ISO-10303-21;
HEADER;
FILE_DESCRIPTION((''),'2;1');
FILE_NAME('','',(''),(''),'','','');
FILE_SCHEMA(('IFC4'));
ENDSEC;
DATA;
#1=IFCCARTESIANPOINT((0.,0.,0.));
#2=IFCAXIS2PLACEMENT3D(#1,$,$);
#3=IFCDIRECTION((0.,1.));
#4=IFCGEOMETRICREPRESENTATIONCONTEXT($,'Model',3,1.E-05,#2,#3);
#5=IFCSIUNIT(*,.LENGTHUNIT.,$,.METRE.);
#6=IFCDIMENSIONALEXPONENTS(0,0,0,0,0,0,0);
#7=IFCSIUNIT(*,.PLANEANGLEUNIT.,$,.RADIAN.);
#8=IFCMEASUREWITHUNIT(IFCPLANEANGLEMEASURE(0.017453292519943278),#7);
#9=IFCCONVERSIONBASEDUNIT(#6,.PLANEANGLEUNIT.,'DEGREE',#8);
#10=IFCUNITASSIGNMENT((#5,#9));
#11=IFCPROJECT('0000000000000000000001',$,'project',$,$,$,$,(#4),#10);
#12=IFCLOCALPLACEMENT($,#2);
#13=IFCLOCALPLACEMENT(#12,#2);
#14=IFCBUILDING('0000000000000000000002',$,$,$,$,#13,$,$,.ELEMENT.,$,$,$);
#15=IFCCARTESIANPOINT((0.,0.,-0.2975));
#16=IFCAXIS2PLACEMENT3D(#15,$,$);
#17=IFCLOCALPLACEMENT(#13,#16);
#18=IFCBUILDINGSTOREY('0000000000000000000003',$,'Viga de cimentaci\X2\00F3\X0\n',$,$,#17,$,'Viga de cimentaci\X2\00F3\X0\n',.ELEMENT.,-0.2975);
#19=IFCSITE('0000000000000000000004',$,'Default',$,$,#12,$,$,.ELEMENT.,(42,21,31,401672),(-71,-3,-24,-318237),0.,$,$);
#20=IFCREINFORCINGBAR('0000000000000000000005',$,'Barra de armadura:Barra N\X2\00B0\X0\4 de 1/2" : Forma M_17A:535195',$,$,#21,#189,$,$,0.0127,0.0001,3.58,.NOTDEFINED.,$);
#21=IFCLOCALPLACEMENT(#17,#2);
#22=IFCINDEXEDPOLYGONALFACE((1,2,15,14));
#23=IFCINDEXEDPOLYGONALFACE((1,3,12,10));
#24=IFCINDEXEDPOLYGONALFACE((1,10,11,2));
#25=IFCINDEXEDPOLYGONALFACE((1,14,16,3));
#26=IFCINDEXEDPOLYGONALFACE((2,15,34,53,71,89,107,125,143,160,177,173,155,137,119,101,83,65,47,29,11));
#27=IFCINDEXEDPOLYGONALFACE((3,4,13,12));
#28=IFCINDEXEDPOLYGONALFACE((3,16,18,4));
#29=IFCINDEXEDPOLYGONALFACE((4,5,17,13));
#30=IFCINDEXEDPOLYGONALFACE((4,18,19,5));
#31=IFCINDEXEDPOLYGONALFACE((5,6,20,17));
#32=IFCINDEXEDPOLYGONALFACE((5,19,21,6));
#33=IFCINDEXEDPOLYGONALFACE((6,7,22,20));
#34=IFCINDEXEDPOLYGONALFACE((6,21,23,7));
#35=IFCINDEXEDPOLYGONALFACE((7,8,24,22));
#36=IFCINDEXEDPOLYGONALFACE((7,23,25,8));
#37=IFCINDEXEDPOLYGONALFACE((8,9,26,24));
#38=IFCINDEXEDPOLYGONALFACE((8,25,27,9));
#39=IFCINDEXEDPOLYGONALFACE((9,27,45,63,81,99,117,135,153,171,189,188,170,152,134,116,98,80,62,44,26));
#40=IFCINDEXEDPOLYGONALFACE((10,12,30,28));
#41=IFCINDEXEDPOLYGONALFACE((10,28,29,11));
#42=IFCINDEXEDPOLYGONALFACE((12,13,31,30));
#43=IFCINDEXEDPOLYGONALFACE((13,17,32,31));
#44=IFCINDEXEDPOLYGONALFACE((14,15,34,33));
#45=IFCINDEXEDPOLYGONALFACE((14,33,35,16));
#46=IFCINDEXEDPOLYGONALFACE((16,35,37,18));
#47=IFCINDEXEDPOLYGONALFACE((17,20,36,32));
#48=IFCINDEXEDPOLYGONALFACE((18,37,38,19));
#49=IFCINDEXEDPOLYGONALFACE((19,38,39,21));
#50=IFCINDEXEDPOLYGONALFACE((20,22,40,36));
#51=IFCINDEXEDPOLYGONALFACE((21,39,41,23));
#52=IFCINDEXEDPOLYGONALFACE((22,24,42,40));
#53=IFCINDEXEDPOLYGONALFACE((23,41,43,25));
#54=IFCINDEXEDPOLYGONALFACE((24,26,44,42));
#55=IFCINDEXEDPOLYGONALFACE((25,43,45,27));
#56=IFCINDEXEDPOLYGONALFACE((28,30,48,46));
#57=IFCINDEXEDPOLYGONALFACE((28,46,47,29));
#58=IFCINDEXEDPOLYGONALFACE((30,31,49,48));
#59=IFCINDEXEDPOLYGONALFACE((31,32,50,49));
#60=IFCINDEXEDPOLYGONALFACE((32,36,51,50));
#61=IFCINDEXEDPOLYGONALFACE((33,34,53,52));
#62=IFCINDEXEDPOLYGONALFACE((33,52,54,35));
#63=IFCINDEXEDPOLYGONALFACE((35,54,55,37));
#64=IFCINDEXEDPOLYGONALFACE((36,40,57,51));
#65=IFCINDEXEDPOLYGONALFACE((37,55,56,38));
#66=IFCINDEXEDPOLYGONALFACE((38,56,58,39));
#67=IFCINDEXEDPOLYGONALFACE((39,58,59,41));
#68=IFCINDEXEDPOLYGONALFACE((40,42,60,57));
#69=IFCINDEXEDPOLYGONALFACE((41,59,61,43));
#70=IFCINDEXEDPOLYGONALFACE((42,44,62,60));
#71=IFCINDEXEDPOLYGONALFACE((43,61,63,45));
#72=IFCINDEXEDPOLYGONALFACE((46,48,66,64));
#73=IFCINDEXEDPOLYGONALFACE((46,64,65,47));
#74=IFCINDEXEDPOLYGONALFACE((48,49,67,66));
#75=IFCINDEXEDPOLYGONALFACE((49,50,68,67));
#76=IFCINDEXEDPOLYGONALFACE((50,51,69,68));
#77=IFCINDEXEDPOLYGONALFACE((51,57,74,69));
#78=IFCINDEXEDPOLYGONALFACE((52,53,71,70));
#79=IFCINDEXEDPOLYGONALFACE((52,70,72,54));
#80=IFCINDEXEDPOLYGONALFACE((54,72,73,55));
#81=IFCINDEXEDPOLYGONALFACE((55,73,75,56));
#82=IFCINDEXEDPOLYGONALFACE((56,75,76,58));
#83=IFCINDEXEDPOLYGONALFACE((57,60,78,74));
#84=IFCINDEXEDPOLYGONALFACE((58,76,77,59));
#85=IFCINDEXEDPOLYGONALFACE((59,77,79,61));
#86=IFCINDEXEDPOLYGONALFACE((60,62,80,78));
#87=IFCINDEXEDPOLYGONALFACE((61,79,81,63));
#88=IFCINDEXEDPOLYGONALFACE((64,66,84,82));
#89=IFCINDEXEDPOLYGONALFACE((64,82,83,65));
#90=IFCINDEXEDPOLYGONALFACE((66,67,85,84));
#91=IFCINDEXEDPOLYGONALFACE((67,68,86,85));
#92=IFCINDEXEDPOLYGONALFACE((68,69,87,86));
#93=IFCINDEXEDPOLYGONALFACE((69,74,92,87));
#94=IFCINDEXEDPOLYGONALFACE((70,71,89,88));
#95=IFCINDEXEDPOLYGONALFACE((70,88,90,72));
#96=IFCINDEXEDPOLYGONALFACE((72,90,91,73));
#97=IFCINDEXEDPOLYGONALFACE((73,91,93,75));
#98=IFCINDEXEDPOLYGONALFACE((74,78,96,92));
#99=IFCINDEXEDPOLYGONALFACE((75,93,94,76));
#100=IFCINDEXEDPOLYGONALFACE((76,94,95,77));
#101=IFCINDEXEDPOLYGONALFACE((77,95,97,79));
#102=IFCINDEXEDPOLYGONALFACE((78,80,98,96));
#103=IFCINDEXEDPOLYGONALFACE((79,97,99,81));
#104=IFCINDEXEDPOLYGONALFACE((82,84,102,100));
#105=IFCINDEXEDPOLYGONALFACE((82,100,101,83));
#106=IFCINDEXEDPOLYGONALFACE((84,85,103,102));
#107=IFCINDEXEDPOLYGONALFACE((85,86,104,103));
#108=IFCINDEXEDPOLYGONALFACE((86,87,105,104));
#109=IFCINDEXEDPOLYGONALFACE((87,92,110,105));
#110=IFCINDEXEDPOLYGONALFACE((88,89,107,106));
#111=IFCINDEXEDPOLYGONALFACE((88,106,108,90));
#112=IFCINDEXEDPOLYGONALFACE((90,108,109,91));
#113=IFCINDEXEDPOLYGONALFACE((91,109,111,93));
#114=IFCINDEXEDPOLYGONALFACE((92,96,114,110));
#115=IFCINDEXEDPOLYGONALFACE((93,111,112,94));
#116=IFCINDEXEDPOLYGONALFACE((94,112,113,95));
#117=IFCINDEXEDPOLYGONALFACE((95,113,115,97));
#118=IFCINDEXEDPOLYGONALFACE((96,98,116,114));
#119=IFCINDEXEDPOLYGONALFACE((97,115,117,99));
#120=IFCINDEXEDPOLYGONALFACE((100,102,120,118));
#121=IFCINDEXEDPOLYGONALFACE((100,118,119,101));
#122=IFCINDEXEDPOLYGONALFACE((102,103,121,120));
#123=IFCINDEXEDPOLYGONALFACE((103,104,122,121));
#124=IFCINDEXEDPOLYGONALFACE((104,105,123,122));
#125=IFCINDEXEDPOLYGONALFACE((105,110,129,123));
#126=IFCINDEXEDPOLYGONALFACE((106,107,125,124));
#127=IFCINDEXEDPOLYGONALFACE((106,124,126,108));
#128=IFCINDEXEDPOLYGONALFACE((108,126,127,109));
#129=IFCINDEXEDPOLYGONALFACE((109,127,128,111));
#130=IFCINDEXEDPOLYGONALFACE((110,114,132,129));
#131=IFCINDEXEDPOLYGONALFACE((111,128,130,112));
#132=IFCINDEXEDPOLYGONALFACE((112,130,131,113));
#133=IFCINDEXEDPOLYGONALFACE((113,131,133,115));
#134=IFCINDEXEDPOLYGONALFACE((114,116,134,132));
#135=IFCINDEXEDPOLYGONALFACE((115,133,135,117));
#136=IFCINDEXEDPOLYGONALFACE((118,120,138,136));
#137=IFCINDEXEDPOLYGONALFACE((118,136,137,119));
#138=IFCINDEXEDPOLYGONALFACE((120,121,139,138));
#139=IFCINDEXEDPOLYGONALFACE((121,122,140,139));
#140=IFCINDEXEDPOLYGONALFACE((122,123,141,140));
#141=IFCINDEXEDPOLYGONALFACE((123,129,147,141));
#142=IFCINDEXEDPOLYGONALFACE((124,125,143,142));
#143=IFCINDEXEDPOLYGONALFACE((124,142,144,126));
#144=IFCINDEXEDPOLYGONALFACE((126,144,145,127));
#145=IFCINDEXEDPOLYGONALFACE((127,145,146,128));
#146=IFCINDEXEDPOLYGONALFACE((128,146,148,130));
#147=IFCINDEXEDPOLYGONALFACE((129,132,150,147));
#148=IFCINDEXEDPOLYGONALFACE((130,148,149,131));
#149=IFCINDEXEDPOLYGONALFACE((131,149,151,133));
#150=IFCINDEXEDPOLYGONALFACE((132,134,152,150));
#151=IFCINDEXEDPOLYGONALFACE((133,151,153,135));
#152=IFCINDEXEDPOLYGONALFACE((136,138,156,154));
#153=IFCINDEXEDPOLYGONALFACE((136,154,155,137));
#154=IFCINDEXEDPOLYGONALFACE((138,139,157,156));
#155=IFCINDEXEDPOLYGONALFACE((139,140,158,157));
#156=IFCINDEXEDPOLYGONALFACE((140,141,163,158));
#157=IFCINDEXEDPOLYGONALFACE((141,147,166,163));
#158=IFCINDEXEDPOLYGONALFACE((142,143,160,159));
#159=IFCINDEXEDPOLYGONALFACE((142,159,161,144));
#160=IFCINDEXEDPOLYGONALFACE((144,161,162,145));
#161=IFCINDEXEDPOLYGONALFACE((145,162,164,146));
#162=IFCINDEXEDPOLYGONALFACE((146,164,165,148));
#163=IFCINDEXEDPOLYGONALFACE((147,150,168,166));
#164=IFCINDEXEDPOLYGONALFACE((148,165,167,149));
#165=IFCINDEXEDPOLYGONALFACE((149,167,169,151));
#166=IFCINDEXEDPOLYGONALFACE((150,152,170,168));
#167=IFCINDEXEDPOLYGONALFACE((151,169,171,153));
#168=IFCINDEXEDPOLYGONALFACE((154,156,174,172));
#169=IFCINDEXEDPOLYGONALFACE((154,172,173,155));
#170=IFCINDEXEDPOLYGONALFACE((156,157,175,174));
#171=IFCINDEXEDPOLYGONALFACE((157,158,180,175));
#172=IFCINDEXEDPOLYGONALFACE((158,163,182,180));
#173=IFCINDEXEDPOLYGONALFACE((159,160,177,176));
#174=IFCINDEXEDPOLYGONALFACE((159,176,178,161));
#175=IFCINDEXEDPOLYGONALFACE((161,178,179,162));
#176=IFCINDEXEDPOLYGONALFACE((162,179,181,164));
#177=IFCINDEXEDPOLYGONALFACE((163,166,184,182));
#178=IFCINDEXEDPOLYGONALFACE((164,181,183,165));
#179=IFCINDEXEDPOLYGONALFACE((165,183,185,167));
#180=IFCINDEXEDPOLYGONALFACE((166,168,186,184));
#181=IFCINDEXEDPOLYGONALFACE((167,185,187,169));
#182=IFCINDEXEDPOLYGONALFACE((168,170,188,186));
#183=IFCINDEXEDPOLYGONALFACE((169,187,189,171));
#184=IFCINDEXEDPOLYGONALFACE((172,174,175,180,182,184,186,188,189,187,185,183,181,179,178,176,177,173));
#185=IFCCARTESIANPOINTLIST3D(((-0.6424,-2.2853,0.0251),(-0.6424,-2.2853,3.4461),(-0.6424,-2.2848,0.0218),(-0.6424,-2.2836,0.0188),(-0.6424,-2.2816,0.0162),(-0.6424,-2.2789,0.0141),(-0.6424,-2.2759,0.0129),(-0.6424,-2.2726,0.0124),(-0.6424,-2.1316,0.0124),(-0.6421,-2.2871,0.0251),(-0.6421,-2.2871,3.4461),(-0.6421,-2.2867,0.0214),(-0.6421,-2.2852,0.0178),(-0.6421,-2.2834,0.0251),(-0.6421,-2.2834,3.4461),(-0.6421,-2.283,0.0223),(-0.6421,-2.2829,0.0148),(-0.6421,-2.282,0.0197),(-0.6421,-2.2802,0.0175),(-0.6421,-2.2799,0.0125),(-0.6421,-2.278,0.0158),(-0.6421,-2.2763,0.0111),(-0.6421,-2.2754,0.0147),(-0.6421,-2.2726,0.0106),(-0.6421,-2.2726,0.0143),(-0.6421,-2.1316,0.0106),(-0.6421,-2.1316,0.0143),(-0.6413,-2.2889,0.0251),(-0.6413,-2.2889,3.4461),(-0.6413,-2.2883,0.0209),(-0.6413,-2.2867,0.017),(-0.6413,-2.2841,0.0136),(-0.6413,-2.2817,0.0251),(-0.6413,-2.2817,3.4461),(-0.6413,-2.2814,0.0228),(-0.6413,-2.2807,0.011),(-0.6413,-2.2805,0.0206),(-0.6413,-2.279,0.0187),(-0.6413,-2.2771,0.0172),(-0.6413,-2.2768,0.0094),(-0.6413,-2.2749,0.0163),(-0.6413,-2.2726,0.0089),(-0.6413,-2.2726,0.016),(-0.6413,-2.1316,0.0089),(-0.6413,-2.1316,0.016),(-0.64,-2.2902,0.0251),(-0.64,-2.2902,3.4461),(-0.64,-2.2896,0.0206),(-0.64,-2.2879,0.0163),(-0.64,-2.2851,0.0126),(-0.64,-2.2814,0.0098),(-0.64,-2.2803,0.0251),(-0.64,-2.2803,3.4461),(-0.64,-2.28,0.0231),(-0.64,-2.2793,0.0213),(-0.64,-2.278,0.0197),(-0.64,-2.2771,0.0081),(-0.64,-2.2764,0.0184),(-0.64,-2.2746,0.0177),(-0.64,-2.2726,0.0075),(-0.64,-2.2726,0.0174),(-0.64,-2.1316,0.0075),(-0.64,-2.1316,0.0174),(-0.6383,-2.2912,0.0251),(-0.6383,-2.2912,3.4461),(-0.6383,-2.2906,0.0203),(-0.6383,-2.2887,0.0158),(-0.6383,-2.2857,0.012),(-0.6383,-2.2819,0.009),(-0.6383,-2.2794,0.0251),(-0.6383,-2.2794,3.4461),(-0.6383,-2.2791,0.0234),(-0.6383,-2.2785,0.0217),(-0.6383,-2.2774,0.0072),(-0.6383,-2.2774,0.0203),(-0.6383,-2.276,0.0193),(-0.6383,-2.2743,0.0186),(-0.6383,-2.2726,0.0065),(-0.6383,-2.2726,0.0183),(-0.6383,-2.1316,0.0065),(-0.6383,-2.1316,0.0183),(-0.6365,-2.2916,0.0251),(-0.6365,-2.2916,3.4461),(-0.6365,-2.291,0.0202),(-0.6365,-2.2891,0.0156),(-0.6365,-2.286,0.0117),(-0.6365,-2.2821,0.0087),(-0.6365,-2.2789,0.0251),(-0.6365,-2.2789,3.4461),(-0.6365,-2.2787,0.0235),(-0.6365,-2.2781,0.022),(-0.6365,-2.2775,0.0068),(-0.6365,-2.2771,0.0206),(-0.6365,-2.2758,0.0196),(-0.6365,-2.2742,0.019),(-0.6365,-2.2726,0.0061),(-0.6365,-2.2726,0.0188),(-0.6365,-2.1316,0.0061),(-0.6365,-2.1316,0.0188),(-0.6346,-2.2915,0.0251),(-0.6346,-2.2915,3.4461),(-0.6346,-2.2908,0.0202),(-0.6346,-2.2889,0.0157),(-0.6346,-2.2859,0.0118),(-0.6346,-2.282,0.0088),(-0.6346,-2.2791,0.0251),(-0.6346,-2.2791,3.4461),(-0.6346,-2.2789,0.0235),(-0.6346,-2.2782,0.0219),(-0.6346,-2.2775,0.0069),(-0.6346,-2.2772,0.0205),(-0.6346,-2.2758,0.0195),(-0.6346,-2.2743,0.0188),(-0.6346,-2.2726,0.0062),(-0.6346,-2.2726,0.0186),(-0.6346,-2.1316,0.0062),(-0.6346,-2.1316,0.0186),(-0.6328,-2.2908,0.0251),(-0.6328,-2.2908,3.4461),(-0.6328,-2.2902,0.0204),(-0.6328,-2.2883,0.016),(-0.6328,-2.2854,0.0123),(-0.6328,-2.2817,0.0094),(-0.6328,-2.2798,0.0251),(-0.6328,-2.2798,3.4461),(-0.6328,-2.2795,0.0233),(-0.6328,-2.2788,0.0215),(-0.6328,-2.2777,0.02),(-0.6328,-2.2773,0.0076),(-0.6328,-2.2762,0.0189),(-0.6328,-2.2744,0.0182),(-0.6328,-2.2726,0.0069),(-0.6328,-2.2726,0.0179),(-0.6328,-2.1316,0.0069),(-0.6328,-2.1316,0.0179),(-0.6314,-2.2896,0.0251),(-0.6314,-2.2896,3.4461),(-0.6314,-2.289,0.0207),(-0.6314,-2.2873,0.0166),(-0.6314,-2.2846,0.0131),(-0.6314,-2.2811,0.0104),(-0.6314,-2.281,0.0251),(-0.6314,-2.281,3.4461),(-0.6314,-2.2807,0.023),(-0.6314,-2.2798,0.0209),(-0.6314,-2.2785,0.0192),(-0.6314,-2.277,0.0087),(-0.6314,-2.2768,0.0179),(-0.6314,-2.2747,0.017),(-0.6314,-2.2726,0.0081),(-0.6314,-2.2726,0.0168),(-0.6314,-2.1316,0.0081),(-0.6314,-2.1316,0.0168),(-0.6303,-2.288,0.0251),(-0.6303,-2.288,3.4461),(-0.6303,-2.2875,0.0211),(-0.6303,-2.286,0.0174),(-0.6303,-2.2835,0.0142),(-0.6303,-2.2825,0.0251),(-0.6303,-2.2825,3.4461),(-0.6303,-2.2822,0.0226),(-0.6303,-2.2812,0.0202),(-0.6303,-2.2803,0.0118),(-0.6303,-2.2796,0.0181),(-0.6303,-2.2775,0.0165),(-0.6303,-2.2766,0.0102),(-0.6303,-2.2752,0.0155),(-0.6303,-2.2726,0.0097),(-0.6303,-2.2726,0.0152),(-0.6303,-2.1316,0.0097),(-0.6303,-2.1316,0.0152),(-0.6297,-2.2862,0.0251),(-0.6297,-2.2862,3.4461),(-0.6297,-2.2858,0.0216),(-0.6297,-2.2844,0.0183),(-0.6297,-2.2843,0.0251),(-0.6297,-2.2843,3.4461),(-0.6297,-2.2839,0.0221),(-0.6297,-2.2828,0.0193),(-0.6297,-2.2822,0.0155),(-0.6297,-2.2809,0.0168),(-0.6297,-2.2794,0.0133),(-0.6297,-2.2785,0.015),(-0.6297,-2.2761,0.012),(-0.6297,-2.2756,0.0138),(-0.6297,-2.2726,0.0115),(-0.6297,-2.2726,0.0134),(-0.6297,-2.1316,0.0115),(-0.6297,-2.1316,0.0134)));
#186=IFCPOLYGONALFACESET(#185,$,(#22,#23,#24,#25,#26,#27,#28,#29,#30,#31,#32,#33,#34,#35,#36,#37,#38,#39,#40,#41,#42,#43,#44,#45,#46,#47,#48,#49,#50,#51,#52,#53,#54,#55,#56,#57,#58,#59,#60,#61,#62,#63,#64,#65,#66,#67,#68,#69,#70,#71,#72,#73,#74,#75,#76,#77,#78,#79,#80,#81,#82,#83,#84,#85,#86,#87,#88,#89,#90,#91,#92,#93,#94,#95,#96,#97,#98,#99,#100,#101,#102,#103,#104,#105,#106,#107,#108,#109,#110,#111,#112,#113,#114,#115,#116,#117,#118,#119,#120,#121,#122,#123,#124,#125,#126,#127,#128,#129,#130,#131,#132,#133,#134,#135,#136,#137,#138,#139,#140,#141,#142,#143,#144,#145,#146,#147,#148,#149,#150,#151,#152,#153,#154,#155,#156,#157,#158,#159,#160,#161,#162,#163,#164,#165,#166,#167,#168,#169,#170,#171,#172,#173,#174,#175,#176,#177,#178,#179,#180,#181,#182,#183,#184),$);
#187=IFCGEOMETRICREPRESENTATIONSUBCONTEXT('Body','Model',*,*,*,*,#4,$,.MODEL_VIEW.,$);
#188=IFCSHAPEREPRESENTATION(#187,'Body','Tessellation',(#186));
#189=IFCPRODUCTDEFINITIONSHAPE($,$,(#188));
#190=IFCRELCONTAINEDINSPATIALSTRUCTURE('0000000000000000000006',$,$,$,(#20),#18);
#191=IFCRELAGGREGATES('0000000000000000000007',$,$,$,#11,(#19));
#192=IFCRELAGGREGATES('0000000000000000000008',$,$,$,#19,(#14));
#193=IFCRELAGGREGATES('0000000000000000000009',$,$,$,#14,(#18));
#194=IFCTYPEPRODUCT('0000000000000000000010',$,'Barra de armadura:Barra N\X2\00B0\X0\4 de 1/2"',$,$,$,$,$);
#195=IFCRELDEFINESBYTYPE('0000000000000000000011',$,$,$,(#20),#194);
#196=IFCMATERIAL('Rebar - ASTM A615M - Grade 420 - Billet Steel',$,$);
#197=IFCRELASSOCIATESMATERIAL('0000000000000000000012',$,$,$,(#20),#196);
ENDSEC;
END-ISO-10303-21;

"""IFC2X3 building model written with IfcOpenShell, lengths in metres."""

from ifc_helpers import new_model, entity, si_unit, converted_unit, direction, frame, origin, place, context, subcontext, project, spatial, material, type_object, element, save


model = new_model("IFC2X3")

# Units and contexts
model_context = context("Model", 3, precision=1e-05, world=origin(), true_north=direction((0.0, 1.0)))
body_context = subcontext(model_context, "Body", "Model", "MODEL_VIEW")
ifc_project = project(units=[si_unit("LENGTHUNIT", "METRE"), converted_unit("PLANEANGLEUNIT", "DEGREE", entity("IfcPlaneAngleMeasure", 0.017453292519943278), si_unit("PLANEANGLEUNIT", "RADIAN"), dimensions=[0, 0, 0, 0, 0, 0, 0])], contexts=[model_context])

# Site, building, storey
site_placement = place(None, origin())
site = spatial("IfcSite", under=ifc_project, at=site_placement, Name="Default", CompositionType="ELEMENT", RefLatitude=(42, 21, 31, 401672), RefLongitude=(-71, -3, -24, -318237), RefElevation=0.0)
building_placement = place(site_placement, origin())
building = spatial("IfcBuilding", under=site, at=building_placement, CompositionType="ELEMENT")
storey_placement = place(building_placement, frame((0.0, 0.0, -0.2975)))
storey = spatial("IfcBuildingStorey", under=building, at=storey_placement, Name="Viga de cimentación", LongName="Viga de cimentación", CompositionType="ELEMENT", Elevation=-0.2975)

# Reinforcing bar
ifc_material = material(Name="Rebar - ASTM A615M - Grade 420 - Billet Steel")
type_product_1 = type_object("IfcTypeProduct", Name="Barra de armadura:Barra N°4 de 1/2\"")
reinforcing_bar_1_placement = place(storey_placement, origin())
element("IfcReinforcingBar", 1, at=reinforcing_bar_1_placement, inside=storey, type_object=type_product_1, material=ifc_material, Name="Barra de armadura:Barra N°4 de 1/2\" : Forma M_17A:535195", BarLength=3.58, BarRole="NOTDEFINED", CrossSectionArea=0.0001, NominalDiameter=0.0127, context=body_context, shape_type="AdvancedSweptSolid", body=[
    entity("IfcSweptDiskSolid", entity("IfcCompositeCurve", [entity("IfcCompositeCurveSegment", "CONTINUOUS", True, entity("IfcPolyline", [entity("IfcCartesianPoint", [-0.636, -2.2853, 3.4461]), entity("IfcCartesianPoint", [-0.636, -2.2853, 0.0251])])), entity("IfcCompositeCurveSegment", "CONTINUOUS", True, entity("IfcTrimmedCurve", entity("IfcCircle", entity("IfcAxis2Placement3D", entity("IfcCartesianPoint", [-0.636, -2.2726, 0.0251]), entity("IfcDirection", [1.0, 0.0, 0.0]), entity("IfcDirection", [0.0, 0.0, -1.0])), 0.0127), [entity("IfcParameterValue", 270.0)], [entity("IfcParameterValue", 360.0)], True, "PARAMETER")), entity("IfcCompositeCurveSegment", "CONTINUOUS", True, entity("IfcPolyline", [entity("IfcCartesianPoint", [-0.636, -2.2726, 0.0124]), entity("IfcCartesianPoint", [-0.636, -2.1316, 0.0124])]))], False), 0.0063, None, 0.0, 92.0),
])

save(model, "model.ifc")
